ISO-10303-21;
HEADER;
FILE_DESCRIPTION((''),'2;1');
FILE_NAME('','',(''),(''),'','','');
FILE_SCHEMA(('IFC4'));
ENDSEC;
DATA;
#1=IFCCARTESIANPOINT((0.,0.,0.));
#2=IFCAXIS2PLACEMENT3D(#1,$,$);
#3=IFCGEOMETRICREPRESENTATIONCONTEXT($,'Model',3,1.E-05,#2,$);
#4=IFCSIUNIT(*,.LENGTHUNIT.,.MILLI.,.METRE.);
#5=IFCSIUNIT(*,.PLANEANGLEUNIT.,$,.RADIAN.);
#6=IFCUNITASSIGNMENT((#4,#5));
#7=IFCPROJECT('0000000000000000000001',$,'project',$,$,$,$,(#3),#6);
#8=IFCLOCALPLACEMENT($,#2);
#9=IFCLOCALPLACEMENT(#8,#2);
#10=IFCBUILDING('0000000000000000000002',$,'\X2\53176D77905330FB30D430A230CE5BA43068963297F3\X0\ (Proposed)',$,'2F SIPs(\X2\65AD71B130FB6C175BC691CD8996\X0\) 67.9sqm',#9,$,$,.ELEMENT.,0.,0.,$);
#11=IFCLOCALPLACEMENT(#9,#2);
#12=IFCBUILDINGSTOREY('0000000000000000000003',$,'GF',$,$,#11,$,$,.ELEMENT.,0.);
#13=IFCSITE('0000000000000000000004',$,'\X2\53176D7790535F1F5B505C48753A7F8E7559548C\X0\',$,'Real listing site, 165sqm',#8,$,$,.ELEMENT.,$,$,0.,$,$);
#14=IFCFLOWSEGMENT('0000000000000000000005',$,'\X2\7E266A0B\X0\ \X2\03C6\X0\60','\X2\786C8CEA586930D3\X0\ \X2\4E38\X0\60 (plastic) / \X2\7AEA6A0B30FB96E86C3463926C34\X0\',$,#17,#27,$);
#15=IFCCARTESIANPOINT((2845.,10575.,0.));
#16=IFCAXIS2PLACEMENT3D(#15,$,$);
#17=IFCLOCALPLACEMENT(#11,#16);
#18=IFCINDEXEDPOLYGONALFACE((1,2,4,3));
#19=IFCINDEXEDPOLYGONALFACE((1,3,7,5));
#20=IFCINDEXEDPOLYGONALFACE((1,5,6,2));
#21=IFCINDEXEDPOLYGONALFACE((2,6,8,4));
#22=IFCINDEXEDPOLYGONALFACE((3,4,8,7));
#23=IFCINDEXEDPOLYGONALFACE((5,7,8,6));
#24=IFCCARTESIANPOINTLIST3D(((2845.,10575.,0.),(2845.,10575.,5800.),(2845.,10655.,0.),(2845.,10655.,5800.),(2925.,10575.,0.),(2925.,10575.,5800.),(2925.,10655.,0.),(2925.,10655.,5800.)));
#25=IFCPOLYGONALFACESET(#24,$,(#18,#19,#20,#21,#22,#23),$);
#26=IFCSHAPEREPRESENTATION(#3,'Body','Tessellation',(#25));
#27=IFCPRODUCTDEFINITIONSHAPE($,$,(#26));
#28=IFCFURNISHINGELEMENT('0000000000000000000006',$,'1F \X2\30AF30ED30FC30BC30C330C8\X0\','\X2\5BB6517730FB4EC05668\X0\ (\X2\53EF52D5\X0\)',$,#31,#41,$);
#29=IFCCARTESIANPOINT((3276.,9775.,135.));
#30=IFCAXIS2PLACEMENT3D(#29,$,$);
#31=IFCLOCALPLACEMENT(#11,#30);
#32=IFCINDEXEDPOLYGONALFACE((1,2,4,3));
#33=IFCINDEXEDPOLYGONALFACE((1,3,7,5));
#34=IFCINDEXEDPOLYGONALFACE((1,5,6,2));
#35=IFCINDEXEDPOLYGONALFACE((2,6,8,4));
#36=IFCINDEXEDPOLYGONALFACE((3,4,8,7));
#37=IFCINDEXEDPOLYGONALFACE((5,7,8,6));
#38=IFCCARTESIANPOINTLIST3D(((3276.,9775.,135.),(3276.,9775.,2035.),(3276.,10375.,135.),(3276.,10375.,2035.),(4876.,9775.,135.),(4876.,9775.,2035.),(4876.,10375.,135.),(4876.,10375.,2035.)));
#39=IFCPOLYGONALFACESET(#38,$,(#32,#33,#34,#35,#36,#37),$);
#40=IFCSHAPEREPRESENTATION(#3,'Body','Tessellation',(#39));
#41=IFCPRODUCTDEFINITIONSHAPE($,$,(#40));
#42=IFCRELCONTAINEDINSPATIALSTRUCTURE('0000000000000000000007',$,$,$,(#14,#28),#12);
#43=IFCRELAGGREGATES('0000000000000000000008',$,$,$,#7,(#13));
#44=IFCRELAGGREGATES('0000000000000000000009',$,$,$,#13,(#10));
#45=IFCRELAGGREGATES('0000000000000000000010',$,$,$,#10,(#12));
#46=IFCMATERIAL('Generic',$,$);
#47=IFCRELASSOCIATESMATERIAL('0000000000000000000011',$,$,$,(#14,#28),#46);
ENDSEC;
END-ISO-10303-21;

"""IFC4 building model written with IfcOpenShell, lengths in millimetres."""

from ifc_helpers import new_model, si_unit, frame, frame_2d, origin, place, context, project, spatial, rectangle, extrude, material, element, save


model = new_model("IFC4")

# Units and contexts
model_context = context("Model", 3, precision=1e-05, world=origin())
ifc_project = project(units=[si_unit("LENGTHUNIT", "METRE", prefix="MILLI"), si_unit("PLANEANGLEUNIT", "RADIAN")], contexts=[model_context])

# Site, building, storey
site_placement = place(None, origin())
site = spatial("IfcSite", under=ifc_project, at=site_placement, Name="北海道弟子屈町美留和", ObjectType="Real listing site, 165sqm", CompositionType="ELEMENT", RefElevation=0.0)
building_placement = place(site_placement, origin())
building = spatial("IfcBuilding", under=site, at=building_placement, Name="北海道・ピアノ室と防音 (Proposed)", ObjectType="2F SIPs(断熱・気密重視) 67.9sqm", CompositionType="ELEMENT", ElevationOfRefHeight=0.0, ElevationOfTerrain=0.0)
storey_placement = place(building_placement, origin())
storey = spatial("IfcBuildingStorey", under=building, at=storey_placement, Name="GF", CompositionType="ELEMENT", Elevation=0.0)

# Shared definitions
ifc_material_1 = material(Name="Generic")

# Flow segment
flow_segment_placement = place(storey_placement, frame((2845.0, 10575.0, 0.0)))
element("IfcFlowSegment", 1, at=flow_segment_placement, inside=storey, material=ifc_material_1, Name="縦樋 φ60", Description="硬質塩ビ 丸60 (plastic) / 竪樋・雨水排水", context=model_context, shape_type="SweptSolid", body=[
    extrude(rectangle(XDim=80.0, YDim=80.0, at=frame_2d((40.0, 40.0))), frame((2845.0, 10575.0, 0.0)), (0.0, 0.0, 1.0), 5800.0),
])

# Furnishing element
furnishing_placement = place(storey_placement, frame((3276.0, 9775.0, 135.0)))
element("IfcFurnishingElement", 2, at=furnishing_placement, inside=storey, material=ifc_material_1, Name="1F クローゼット", Description="家具・什器 (可動)", context=model_context, shape_type="SweptSolid", body=[
    extrude(rectangle(XDim=1600.0, YDim=600.0, at=frame_2d((800.0, 300.0))), frame((3276.0, 9775.0, 135.0)), (0.0, 0.0, 1.0), 1900.0),
])

save(model, "model.ifc")
